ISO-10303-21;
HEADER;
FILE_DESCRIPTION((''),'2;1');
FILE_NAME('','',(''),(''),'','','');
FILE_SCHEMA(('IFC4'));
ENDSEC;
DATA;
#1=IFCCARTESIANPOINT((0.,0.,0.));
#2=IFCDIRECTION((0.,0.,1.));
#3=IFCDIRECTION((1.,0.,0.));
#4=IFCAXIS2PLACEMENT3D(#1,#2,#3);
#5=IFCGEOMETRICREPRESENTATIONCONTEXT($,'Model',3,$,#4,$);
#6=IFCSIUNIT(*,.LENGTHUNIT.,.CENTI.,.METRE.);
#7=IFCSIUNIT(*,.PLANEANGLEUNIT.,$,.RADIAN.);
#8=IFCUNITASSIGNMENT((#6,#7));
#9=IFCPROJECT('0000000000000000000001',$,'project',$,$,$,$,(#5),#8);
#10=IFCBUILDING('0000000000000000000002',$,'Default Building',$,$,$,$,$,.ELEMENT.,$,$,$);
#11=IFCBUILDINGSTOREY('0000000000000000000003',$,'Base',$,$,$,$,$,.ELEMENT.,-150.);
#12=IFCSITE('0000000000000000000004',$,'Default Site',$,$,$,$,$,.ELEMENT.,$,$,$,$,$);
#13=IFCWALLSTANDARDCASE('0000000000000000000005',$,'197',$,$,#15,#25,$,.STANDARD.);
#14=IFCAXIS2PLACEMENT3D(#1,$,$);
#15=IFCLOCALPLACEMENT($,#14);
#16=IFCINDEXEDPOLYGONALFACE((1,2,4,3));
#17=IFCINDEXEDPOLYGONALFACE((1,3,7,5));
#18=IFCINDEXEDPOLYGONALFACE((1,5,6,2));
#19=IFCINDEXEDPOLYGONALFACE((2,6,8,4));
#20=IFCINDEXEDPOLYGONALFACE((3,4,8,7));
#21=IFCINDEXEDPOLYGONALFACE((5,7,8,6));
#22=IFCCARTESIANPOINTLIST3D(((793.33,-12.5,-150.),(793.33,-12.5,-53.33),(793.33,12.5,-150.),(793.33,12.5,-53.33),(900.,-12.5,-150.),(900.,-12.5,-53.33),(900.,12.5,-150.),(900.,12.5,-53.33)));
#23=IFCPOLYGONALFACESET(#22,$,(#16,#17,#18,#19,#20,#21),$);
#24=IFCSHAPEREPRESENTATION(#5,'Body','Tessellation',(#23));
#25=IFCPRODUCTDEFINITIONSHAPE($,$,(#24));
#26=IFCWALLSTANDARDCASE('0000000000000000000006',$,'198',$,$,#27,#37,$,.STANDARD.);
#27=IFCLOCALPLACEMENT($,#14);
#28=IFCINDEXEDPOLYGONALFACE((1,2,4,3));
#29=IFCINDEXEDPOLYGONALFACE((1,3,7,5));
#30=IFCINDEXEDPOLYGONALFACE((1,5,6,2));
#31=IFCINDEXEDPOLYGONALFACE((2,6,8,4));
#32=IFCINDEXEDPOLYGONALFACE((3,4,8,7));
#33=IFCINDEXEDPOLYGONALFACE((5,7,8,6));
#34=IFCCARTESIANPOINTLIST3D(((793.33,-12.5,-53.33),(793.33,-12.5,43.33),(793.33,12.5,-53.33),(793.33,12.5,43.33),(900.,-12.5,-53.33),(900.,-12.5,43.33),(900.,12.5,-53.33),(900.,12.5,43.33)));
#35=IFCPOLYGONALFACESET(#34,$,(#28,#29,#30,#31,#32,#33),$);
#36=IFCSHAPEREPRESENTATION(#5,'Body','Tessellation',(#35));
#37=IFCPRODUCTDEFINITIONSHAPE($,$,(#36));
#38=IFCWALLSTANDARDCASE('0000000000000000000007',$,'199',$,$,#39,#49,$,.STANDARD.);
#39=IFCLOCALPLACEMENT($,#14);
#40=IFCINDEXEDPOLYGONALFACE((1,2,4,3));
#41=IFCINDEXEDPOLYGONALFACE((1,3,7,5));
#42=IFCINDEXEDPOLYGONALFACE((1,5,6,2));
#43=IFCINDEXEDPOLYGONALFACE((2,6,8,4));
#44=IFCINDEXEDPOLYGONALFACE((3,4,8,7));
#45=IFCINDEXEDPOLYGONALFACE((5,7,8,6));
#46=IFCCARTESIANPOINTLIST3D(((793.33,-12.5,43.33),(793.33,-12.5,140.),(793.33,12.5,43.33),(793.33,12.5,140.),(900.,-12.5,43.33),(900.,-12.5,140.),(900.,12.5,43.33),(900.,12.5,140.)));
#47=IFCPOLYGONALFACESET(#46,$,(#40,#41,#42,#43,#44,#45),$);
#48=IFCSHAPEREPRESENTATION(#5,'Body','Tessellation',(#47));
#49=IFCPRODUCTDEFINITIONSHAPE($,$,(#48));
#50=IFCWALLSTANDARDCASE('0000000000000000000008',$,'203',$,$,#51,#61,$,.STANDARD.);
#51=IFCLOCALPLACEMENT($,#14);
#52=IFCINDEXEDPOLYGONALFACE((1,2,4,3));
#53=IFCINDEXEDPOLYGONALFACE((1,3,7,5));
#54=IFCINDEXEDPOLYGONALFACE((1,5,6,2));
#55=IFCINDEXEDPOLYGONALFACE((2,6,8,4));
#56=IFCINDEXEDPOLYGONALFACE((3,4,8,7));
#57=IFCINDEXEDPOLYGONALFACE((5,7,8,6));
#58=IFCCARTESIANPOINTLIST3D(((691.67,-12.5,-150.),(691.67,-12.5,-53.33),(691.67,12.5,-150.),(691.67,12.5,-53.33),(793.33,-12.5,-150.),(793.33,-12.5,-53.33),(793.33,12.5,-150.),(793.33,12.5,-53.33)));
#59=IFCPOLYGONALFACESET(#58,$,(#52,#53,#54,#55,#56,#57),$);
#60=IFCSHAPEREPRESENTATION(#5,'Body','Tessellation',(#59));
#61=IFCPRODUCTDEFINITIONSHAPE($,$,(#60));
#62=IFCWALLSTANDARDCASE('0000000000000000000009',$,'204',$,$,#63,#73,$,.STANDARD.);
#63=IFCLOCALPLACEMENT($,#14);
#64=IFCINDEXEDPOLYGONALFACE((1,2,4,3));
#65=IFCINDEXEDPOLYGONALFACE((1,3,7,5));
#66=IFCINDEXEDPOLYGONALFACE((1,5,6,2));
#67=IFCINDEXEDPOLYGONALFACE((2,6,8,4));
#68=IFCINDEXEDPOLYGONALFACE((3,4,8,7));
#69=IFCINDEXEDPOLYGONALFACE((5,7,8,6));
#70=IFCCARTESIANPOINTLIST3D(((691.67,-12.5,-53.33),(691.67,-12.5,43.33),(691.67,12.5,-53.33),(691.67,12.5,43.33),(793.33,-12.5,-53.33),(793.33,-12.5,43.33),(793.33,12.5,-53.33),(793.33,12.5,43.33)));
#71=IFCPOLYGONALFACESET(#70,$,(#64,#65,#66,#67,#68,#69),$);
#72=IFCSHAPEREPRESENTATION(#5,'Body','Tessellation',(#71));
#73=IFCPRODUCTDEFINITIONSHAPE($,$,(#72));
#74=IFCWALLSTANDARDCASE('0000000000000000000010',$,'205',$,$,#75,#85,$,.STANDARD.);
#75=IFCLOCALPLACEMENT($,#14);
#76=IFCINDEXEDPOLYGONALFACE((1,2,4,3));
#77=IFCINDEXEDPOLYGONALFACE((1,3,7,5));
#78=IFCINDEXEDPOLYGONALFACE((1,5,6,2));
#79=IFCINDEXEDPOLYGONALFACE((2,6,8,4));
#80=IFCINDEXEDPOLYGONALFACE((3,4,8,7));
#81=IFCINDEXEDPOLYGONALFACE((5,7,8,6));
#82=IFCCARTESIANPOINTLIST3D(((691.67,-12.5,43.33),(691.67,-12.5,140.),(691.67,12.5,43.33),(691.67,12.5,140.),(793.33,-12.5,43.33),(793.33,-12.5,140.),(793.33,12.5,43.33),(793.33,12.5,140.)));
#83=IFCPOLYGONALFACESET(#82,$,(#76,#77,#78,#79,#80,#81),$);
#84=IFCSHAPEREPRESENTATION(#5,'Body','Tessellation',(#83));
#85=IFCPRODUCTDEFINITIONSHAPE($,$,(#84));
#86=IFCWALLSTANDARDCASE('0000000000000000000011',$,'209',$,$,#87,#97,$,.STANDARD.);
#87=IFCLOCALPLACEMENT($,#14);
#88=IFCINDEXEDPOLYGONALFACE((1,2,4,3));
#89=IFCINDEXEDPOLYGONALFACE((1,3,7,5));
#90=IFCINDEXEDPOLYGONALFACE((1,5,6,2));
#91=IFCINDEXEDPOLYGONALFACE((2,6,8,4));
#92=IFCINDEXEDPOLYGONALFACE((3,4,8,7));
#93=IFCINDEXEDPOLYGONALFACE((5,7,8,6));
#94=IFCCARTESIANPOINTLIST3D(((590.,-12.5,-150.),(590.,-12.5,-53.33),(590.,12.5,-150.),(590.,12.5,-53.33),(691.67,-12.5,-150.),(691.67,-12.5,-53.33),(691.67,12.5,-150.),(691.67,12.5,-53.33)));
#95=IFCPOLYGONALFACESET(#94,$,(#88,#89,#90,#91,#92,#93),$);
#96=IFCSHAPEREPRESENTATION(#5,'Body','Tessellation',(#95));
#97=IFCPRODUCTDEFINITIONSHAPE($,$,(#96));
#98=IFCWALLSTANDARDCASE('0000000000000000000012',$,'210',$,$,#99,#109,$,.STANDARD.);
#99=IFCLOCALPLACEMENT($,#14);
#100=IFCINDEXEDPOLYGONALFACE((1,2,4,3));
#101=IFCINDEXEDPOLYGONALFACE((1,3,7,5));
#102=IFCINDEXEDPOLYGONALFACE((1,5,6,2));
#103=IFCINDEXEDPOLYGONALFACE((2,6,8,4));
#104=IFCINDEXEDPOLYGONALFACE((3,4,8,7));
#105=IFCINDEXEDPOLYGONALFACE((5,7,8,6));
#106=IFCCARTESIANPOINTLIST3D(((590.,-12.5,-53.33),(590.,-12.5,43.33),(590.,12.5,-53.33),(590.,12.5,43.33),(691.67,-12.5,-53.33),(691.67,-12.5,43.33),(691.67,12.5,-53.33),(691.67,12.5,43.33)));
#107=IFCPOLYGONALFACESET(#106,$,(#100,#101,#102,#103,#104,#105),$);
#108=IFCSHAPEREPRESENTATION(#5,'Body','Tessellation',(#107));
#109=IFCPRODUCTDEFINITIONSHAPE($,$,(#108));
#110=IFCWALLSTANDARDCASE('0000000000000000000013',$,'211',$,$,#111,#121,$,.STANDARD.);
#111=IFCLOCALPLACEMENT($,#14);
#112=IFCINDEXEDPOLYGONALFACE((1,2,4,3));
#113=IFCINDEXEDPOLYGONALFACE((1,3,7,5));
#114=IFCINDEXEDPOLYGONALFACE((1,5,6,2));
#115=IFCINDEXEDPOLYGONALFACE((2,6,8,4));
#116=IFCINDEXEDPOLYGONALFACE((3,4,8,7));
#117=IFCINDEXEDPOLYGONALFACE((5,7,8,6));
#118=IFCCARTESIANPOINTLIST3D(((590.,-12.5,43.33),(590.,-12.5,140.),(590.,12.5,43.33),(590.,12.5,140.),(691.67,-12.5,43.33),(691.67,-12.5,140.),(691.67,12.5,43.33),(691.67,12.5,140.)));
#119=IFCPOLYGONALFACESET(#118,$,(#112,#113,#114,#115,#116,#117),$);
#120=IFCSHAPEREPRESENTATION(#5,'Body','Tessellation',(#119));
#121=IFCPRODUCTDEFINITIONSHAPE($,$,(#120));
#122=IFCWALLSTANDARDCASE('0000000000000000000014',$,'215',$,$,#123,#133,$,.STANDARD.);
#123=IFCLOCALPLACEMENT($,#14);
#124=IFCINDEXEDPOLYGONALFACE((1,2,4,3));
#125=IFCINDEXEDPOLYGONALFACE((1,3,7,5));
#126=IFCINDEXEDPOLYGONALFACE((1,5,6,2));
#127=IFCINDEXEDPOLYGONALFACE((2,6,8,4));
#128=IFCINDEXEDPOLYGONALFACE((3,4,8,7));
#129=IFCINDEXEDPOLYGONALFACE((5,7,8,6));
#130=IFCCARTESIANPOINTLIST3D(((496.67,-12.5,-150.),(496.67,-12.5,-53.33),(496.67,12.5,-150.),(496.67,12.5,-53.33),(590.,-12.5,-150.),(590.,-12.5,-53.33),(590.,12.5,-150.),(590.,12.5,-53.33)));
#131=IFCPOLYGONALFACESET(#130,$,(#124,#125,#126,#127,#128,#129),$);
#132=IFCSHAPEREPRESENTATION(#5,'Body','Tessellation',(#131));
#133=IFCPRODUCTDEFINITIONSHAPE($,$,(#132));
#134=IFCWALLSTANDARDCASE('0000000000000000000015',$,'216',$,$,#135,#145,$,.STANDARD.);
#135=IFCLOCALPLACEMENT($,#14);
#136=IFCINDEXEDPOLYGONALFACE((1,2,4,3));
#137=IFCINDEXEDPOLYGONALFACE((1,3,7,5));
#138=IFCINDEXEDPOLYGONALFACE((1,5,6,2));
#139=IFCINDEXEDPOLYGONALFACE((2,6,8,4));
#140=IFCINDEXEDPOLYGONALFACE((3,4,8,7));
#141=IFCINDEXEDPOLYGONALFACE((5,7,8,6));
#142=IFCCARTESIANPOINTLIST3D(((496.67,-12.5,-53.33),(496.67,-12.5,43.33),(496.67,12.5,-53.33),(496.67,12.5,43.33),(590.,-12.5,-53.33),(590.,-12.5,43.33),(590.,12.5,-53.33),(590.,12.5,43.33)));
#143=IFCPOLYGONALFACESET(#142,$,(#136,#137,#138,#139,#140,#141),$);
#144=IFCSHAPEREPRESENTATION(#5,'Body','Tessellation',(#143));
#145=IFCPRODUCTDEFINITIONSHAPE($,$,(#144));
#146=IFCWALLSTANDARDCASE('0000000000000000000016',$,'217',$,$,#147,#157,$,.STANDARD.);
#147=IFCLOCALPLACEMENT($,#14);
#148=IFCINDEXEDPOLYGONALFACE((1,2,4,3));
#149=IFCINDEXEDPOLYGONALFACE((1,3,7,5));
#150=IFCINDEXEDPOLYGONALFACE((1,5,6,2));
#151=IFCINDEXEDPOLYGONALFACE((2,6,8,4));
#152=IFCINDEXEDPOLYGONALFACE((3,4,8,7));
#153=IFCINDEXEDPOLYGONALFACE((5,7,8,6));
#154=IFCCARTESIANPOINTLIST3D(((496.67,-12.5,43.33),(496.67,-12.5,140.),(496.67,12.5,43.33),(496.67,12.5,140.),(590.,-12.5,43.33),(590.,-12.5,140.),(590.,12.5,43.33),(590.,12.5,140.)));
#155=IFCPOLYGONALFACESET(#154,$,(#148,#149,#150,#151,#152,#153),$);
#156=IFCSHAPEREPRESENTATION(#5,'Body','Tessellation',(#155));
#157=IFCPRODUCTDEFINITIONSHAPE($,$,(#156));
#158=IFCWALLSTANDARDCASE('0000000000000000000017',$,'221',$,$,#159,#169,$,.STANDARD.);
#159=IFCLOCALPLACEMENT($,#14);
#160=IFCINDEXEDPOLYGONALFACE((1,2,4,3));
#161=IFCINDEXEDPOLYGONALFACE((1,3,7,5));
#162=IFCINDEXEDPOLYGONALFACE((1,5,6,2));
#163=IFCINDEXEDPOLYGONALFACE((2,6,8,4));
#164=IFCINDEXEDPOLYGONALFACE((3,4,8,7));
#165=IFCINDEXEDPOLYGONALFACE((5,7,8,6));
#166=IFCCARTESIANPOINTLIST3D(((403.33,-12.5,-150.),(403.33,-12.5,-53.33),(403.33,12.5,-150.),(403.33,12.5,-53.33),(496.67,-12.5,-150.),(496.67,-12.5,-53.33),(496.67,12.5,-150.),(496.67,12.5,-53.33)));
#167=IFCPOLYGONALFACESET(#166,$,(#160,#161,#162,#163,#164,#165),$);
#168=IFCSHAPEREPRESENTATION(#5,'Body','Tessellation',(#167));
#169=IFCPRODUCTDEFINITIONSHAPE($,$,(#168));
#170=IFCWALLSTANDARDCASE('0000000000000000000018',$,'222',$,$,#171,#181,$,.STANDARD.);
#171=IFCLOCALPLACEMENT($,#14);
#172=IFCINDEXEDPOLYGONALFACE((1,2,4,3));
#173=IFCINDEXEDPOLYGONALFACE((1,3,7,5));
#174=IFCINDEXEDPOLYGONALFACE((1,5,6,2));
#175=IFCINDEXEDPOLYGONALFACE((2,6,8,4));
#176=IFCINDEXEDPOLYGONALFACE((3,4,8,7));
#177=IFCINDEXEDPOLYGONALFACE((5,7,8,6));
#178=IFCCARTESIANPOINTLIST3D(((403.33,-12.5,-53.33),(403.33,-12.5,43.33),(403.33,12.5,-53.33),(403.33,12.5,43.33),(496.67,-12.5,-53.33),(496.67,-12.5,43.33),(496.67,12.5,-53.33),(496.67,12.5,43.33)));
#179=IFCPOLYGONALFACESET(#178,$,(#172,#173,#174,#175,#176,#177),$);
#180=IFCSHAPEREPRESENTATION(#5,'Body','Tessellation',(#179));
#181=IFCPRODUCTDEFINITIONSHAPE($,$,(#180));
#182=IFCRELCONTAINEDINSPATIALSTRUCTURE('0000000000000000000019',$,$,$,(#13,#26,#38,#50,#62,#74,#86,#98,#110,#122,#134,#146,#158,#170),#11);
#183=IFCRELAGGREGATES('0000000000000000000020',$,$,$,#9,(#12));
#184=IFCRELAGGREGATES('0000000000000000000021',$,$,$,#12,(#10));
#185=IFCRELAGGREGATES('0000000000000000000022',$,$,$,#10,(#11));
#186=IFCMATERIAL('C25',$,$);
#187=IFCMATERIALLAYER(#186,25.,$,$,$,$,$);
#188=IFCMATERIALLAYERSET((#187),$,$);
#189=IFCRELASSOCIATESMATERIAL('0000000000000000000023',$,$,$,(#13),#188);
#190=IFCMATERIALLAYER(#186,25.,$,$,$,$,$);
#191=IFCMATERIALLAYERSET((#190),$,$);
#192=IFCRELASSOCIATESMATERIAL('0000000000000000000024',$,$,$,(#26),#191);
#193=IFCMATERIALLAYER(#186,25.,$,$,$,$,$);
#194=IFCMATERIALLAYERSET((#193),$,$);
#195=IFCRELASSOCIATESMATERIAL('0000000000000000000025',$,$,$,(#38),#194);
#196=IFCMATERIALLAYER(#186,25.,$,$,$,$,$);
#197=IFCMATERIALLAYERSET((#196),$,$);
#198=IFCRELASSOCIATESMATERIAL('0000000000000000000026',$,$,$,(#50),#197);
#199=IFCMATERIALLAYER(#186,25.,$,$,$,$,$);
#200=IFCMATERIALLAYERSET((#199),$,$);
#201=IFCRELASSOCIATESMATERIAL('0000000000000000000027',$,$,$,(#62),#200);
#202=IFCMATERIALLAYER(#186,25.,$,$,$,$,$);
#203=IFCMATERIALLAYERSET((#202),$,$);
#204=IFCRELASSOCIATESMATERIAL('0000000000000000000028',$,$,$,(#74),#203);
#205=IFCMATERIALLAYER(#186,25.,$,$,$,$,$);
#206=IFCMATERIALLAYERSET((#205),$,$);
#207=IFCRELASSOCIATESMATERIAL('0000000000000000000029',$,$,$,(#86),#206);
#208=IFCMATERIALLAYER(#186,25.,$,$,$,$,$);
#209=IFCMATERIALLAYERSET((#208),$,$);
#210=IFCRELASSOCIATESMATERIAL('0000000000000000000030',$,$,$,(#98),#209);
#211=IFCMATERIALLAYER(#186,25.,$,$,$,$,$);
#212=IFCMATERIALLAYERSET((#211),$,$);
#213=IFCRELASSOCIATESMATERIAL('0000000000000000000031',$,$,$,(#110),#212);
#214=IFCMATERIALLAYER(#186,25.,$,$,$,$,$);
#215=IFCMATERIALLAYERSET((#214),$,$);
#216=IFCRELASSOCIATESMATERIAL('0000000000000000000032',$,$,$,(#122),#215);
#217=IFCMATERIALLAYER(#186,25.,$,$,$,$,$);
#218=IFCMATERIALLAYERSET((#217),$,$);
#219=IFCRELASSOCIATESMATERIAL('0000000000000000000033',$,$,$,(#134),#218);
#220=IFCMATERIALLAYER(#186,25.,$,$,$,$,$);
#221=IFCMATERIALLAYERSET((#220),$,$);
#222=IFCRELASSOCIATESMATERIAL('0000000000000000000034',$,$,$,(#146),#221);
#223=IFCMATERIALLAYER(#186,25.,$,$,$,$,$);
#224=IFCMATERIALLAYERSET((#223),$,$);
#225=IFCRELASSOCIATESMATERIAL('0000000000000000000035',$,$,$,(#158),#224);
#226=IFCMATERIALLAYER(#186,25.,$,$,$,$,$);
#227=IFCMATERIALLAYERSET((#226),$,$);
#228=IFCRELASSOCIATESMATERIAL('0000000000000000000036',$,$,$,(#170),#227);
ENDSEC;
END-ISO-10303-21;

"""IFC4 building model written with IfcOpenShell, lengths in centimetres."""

from ifc_helpers import new_model, si_unit, frame, origin_with_axes, origin_2d_with_axis, place, context, project, spatial, rectangle, extrude, material, layer, layer_set, layer_usage, element, save


model = new_model("IFC4")

# Units and contexts
model_context = context("Model", 3, world=origin_with_axes())
ifc_project = project(units=[si_unit("LENGTHUNIT", "METRE", prefix="CENTI"), si_unit("PLANEANGLEUNIT", "RADIAN")], contexts=[model_context])

# Site, building, storey
site = spatial("IfcSite", under=ifc_project, Name="Default Site", CompositionType="ELEMENT")
building = spatial("IfcBuilding", under=site, Name="Default Building", CompositionType="ELEMENT")
storey = spatial("IfcBuildingStorey", under=building, Name="Base", CompositionType="ELEMENT", Elevation=-150.0)

# Shared definitions
ifc_material = material(Name="C25")

# Walls
ifc_layer_1 = layer(ifc_material, 25.0)
ifc_layer_set_1 = layer_set([ifc_layer_1])
ifc_layer_usage_1 = layer_usage(ifc_layer_set_1, "AXIS2", "POSITIVE", -25.0)
wall_1_placement = place(None, frame((846.67, 0.0, -150.0), z_axis=(0.0, 0.0, 1.0), x_axis=(-1.0, 0.0, 0.0)))
element("IfcWallStandardCase", 1, at=wall_1_placement, inside=storey, material=ifc_layer_usage_1, Name="197", PredefinedType="STANDARD", context=model_context, shape_type="SweptSolid", body=[
    extrude(rectangle(XDim=106.67, YDim=25.0, at=origin_2d_with_axis()), origin_with_axes(), (0.0, 0.0, 1.0), 96.67),
])
ifc_layer_2 = layer(ifc_material, 25.0)
ifc_layer_set_2 = layer_set([ifc_layer_2])
ifc_layer_usage_2 = layer_usage(ifc_layer_set_2, "AXIS2", "POSITIVE", -25.0)
wall_2_placement = place(None, frame((846.67, 0.0, -53.33), z_axis=(0.0, 0.0, 1.0), x_axis=(-1.0, 0.0, 0.0)))
element("IfcWallStandardCase", 2, at=wall_2_placement, inside=storey, material=ifc_layer_usage_2, Name="198", PredefinedType="STANDARD", context=model_context, shape_type="SweptSolid", body=[
    extrude(rectangle(XDim=106.67, YDim=25.0, at=origin_2d_with_axis()), origin_with_axes(), (0.0, 0.0, 1.0), 96.67),
])
ifc_layer_3 = layer(ifc_material, 25.0)
ifc_layer_set_3 = layer_set([ifc_layer_3])
ifc_layer_usage_3 = layer_usage(ifc_layer_set_3, "AXIS2", "POSITIVE", -25.0)
wall_3_placement = place(None, frame((846.67, 0.0, 43.33), z_axis=(0.0, 0.0, 1.0), x_axis=(-1.0, 0.0, 0.0)))
element("IfcWallStandardCase", 3, at=wall_3_placement, inside=storey, material=ifc_layer_usage_3, Name="199", PredefinedType="STANDARD", context=model_context, shape_type="SweptSolid", body=[
    extrude(rectangle(XDim=106.67, YDim=25.0, at=origin_2d_with_axis()), origin_with_axes(), (0.0, 0.0, 1.0), 96.67),
])
ifc_layer_4 = layer(ifc_material, 25.0)
ifc_layer_set_4 = layer_set([ifc_layer_4])
ifc_layer_usage_4 = layer_usage(ifc_layer_set_4, "AXIS2", "POSITIVE", -25.0)
wall_4_placement = place(None, frame((742.5, 0.0, -150.0), z_axis=(0.0, 0.0, 1.0), x_axis=(-1.0, 0.0, 0.0)))
element("IfcWallStandardCase", 4, at=wall_4_placement, inside=storey, material=ifc_layer_usage_4, Name="203", PredefinedType="STANDARD", context=model_context, shape_type="SweptSolid", body=[
    extrude(rectangle(XDim=101.67, YDim=25.0, at=origin_2d_with_axis()), origin_with_axes(), (0.0, 0.0, 1.0), 96.67),
])
ifc_layer_5 = layer(ifc_material, 25.0)
ifc_layer_set_5 = layer_set([ifc_layer_5])
ifc_layer_usage_5 = layer_usage(ifc_layer_set_5, "AXIS2", "POSITIVE", -25.0)
wall_5_placement = place(None, frame((742.5, 0.0, -53.33), z_axis=(0.0, 0.0, 1.0), x_axis=(-1.0, 0.0, 0.0)))
element("IfcWallStandardCase", 5, at=wall_5_placement, inside=storey, material=ifc_layer_usage_5, Name="204", PredefinedType="STANDARD", context=model_context, shape_type="SweptSolid", body=[
    extrude(rectangle(XDim=101.67, YDim=25.0, at=origin_2d_with_axis()), origin_with_axes(), (0.0, 0.0, 1.0), 96.67),
])
ifc_layer_6 = layer(ifc_material, 25.0)
ifc_layer_set_6 = layer_set([ifc_layer_6])
ifc_layer_usage_6 = layer_usage(ifc_layer_set_6, "AXIS2", "POSITIVE", -25.0)
wall_6_placement = place(None, frame((742.5, 0.0, 43.33), z_axis=(0.0, 0.0, 1.0), x_axis=(-1.0, 0.0, 0.0)))
element("IfcWallStandardCase", 6, at=wall_6_placement, inside=storey, material=ifc_layer_usage_6, Name="205", PredefinedType="STANDARD", context=model_context, shape_type="SweptSolid", body=[
    extrude(rectangle(XDim=101.67, YDim=25.0, at=origin_2d_with_axis()), origin_with_axes(), (0.0, 0.0, 1.0), 96.67),
])
ifc_layer_7 = layer(ifc_material, 25.0)
ifc_layer_set_7 = layer_set([ifc_layer_7])
ifc_layer_usage_7 = layer_usage(ifc_layer_set_7, "AXIS2", "POSITIVE", -25.0)
wall_7_placement = place(None, frame((640.83, 0.0, -150.0), z_axis=(0.0, 0.0, 1.0), x_axis=(-1.0, 0.0, 0.0)))
element("IfcWallStandardCase", 7, at=wall_7_placement, inside=storey, material=ifc_layer_usage_7, Name="209", PredefinedType="STANDARD", context=model_context, shape_type="SweptSolid", body=[
    extrude(rectangle(XDim=101.67, YDim=25.0, at=origin_2d_with_axis()), origin_with_axes(), (0.0, 0.0, 1.0), 96.67),
])
ifc_layer_8 = layer(ifc_material, 25.0)
ifc_layer_set_8 = layer_set([ifc_layer_8])
ifc_layer_usage_8 = layer_usage(ifc_layer_set_8, "AXIS2", "POSITIVE", -25.0)
wall_8_placement = place(None, frame((640.83, 0.0, -53.33), z_axis=(0.0, 0.0, 1.0), x_axis=(-1.0, 0.0, 0.0)))
element("IfcWallStandardCase", 8, at=wall_8_placement, inside=storey, material=ifc_layer_usage_8, Name="210", PredefinedType="STANDARD", context=model_context, shape_type="SweptSolid", body=[
    extrude(rectangle(XDim=101.67, YDim=25.0, at=origin_2d_with_axis()), origin_with_axes(), (0.0, 0.0, 1.0), 96.67),
])
ifc_layer_9 = layer(ifc_material, 25.0)
ifc_layer_set_9 = layer_set([ifc_layer_9])
ifc_layer_usage_9 = layer_usage(ifc_layer_set_9, "AXIS2", "POSITIVE", -25.0)
wall_9_placement = place(None, frame((640.83, 0.0, 43.33), z_axis=(0.0, 0.0, 1.0), x_axis=(-1.0, 0.0, 0.0)))
element("IfcWallStandardCase", 9, at=wall_9_placement, inside=storey, material=ifc_layer_usage_9, Name="211", PredefinedType="STANDARD", context=model_context, shape_type="SweptSolid", body=[
    extrude(rectangle(XDim=101.67, YDim=25.0, at=origin_2d_with_axis()), origin_with_axes(), (0.0, 0.0, 1.0), 96.67),
])
ifc_layer_10 = layer(ifc_material, 25.0)
ifc_layer_set_10 = layer_set([ifc_layer_10])
ifc_layer_usage_10 = layer_usage(ifc_layer_set_10, "AXIS2", "POSITIVE", -25.0)
wall_10_placement = place(None, frame((543.33, 0.0, -150.0), z_axis=(0.0, 0.0, 1.0), x_axis=(-1.0, 0.0, 0.0)))
element("IfcWallStandardCase", 10, at=wall_10_placement, inside=storey, material=ifc_layer_usage_10, Name="215", PredefinedType="STANDARD", context=model_context, shape_type="SweptSolid", body=[
    extrude(rectangle(XDim=93.33, YDim=25.0, at=origin_2d_with_axis()), origin_with_axes(), (0.0, 0.0, 1.0), 96.67),
])
ifc_layer_11 = layer(ifc_material, 25.0)
ifc_layer_set_11 = layer_set([ifc_layer_11])
ifc_layer_usage_11 = layer_usage(ifc_layer_set_11, "AXIS2", "POSITIVE", -25.0)
wall_11_placement = place(None, frame((543.33, 0.0, -53.33), z_axis=(0.0, 0.0, 1.0), x_axis=(-1.0, 0.0, 0.0)))
element("IfcWallStandardCase", 11, at=wall_11_placement, inside=storey, material=ifc_layer_usage_11, Name="216", PredefinedType="STANDARD", context=model_context, shape_type="SweptSolid", body=[
    extrude(rectangle(XDim=93.33, YDim=25.0, at=origin_2d_with_axis()), origin_with_axes(), (0.0, 0.0, 1.0), 96.67),
])
ifc_layer_12 = layer(ifc_material, 25.0)
ifc_layer_set_12 = layer_set([ifc_layer_12])
ifc_layer_usage_12 = layer_usage(ifc_layer_set_12, "AXIS2", "POSITIVE", -25.0)
wall_12_placement = place(None, frame((543.33, 0.0, 43.33), z_axis=(0.0, 0.0, 1.0), x_axis=(-1.0, 0.0, 0.0)))
element("IfcWallStandardCase", 12, at=wall_12_placement, inside=storey, material=ifc_layer_usage_12, Name="217", PredefinedType="STANDARD", context=model_context, shape_type="SweptSolid", body=[
    extrude(rectangle(XDim=93.33, YDim=25.0, at=origin_2d_with_axis()), origin_with_axes(), (0.0, 0.0, 1.0), 96.67),
])
ifc_layer_13 = layer(ifc_material, 25.0)
ifc_layer_set_13 = layer_set([ifc_layer_13])
ifc_layer_usage_13 = layer_usage(ifc_layer_set_13, "AXIS2", "POSITIVE", -25.0)
wall_13_placement = place(None, frame((450.0, 0.0, -150.0), z_axis=(0.0, 0.0, 1.0), x_axis=(-1.0, 0.0, 0.0)))
element("IfcWallStandardCase", 13, at=wall_13_placement, inside=storey, material=ifc_layer_usage_13, Name="221", PredefinedType="STANDARD", context=model_context, shape_type="SweptSolid", body=[
    extrude(rectangle(XDim=93.33, YDim=25.0, at=origin_2d_with_axis()), origin_with_axes(), (0.0, 0.0, 1.0), 96.67),
])
ifc_layer_14 = layer(ifc_material, 25.0)
ifc_layer_set_14 = layer_set([ifc_layer_14])
ifc_layer_usage_14 = layer_usage(ifc_layer_set_14, "AXIS2", "POSITIVE", -25.0)
wall_14_placement = place(None, frame((450.0, 0.0, -53.33), z_axis=(0.0, 0.0, 1.0), x_axis=(-1.0, 0.0, 0.0)))
element("IfcWallStandardCase", 14, at=wall_14_placement, inside=storey, material=ifc_layer_usage_14, Name="222", PredefinedType="STANDARD", context=model_context, shape_type="SweptSolid", body=[
    extrude(rectangle(XDim=93.33, YDim=25.0, at=origin_2d_with_axis()), origin_with_axes(), (0.0, 0.0, 1.0), 96.67),
])

save(model, "model.ifc")
